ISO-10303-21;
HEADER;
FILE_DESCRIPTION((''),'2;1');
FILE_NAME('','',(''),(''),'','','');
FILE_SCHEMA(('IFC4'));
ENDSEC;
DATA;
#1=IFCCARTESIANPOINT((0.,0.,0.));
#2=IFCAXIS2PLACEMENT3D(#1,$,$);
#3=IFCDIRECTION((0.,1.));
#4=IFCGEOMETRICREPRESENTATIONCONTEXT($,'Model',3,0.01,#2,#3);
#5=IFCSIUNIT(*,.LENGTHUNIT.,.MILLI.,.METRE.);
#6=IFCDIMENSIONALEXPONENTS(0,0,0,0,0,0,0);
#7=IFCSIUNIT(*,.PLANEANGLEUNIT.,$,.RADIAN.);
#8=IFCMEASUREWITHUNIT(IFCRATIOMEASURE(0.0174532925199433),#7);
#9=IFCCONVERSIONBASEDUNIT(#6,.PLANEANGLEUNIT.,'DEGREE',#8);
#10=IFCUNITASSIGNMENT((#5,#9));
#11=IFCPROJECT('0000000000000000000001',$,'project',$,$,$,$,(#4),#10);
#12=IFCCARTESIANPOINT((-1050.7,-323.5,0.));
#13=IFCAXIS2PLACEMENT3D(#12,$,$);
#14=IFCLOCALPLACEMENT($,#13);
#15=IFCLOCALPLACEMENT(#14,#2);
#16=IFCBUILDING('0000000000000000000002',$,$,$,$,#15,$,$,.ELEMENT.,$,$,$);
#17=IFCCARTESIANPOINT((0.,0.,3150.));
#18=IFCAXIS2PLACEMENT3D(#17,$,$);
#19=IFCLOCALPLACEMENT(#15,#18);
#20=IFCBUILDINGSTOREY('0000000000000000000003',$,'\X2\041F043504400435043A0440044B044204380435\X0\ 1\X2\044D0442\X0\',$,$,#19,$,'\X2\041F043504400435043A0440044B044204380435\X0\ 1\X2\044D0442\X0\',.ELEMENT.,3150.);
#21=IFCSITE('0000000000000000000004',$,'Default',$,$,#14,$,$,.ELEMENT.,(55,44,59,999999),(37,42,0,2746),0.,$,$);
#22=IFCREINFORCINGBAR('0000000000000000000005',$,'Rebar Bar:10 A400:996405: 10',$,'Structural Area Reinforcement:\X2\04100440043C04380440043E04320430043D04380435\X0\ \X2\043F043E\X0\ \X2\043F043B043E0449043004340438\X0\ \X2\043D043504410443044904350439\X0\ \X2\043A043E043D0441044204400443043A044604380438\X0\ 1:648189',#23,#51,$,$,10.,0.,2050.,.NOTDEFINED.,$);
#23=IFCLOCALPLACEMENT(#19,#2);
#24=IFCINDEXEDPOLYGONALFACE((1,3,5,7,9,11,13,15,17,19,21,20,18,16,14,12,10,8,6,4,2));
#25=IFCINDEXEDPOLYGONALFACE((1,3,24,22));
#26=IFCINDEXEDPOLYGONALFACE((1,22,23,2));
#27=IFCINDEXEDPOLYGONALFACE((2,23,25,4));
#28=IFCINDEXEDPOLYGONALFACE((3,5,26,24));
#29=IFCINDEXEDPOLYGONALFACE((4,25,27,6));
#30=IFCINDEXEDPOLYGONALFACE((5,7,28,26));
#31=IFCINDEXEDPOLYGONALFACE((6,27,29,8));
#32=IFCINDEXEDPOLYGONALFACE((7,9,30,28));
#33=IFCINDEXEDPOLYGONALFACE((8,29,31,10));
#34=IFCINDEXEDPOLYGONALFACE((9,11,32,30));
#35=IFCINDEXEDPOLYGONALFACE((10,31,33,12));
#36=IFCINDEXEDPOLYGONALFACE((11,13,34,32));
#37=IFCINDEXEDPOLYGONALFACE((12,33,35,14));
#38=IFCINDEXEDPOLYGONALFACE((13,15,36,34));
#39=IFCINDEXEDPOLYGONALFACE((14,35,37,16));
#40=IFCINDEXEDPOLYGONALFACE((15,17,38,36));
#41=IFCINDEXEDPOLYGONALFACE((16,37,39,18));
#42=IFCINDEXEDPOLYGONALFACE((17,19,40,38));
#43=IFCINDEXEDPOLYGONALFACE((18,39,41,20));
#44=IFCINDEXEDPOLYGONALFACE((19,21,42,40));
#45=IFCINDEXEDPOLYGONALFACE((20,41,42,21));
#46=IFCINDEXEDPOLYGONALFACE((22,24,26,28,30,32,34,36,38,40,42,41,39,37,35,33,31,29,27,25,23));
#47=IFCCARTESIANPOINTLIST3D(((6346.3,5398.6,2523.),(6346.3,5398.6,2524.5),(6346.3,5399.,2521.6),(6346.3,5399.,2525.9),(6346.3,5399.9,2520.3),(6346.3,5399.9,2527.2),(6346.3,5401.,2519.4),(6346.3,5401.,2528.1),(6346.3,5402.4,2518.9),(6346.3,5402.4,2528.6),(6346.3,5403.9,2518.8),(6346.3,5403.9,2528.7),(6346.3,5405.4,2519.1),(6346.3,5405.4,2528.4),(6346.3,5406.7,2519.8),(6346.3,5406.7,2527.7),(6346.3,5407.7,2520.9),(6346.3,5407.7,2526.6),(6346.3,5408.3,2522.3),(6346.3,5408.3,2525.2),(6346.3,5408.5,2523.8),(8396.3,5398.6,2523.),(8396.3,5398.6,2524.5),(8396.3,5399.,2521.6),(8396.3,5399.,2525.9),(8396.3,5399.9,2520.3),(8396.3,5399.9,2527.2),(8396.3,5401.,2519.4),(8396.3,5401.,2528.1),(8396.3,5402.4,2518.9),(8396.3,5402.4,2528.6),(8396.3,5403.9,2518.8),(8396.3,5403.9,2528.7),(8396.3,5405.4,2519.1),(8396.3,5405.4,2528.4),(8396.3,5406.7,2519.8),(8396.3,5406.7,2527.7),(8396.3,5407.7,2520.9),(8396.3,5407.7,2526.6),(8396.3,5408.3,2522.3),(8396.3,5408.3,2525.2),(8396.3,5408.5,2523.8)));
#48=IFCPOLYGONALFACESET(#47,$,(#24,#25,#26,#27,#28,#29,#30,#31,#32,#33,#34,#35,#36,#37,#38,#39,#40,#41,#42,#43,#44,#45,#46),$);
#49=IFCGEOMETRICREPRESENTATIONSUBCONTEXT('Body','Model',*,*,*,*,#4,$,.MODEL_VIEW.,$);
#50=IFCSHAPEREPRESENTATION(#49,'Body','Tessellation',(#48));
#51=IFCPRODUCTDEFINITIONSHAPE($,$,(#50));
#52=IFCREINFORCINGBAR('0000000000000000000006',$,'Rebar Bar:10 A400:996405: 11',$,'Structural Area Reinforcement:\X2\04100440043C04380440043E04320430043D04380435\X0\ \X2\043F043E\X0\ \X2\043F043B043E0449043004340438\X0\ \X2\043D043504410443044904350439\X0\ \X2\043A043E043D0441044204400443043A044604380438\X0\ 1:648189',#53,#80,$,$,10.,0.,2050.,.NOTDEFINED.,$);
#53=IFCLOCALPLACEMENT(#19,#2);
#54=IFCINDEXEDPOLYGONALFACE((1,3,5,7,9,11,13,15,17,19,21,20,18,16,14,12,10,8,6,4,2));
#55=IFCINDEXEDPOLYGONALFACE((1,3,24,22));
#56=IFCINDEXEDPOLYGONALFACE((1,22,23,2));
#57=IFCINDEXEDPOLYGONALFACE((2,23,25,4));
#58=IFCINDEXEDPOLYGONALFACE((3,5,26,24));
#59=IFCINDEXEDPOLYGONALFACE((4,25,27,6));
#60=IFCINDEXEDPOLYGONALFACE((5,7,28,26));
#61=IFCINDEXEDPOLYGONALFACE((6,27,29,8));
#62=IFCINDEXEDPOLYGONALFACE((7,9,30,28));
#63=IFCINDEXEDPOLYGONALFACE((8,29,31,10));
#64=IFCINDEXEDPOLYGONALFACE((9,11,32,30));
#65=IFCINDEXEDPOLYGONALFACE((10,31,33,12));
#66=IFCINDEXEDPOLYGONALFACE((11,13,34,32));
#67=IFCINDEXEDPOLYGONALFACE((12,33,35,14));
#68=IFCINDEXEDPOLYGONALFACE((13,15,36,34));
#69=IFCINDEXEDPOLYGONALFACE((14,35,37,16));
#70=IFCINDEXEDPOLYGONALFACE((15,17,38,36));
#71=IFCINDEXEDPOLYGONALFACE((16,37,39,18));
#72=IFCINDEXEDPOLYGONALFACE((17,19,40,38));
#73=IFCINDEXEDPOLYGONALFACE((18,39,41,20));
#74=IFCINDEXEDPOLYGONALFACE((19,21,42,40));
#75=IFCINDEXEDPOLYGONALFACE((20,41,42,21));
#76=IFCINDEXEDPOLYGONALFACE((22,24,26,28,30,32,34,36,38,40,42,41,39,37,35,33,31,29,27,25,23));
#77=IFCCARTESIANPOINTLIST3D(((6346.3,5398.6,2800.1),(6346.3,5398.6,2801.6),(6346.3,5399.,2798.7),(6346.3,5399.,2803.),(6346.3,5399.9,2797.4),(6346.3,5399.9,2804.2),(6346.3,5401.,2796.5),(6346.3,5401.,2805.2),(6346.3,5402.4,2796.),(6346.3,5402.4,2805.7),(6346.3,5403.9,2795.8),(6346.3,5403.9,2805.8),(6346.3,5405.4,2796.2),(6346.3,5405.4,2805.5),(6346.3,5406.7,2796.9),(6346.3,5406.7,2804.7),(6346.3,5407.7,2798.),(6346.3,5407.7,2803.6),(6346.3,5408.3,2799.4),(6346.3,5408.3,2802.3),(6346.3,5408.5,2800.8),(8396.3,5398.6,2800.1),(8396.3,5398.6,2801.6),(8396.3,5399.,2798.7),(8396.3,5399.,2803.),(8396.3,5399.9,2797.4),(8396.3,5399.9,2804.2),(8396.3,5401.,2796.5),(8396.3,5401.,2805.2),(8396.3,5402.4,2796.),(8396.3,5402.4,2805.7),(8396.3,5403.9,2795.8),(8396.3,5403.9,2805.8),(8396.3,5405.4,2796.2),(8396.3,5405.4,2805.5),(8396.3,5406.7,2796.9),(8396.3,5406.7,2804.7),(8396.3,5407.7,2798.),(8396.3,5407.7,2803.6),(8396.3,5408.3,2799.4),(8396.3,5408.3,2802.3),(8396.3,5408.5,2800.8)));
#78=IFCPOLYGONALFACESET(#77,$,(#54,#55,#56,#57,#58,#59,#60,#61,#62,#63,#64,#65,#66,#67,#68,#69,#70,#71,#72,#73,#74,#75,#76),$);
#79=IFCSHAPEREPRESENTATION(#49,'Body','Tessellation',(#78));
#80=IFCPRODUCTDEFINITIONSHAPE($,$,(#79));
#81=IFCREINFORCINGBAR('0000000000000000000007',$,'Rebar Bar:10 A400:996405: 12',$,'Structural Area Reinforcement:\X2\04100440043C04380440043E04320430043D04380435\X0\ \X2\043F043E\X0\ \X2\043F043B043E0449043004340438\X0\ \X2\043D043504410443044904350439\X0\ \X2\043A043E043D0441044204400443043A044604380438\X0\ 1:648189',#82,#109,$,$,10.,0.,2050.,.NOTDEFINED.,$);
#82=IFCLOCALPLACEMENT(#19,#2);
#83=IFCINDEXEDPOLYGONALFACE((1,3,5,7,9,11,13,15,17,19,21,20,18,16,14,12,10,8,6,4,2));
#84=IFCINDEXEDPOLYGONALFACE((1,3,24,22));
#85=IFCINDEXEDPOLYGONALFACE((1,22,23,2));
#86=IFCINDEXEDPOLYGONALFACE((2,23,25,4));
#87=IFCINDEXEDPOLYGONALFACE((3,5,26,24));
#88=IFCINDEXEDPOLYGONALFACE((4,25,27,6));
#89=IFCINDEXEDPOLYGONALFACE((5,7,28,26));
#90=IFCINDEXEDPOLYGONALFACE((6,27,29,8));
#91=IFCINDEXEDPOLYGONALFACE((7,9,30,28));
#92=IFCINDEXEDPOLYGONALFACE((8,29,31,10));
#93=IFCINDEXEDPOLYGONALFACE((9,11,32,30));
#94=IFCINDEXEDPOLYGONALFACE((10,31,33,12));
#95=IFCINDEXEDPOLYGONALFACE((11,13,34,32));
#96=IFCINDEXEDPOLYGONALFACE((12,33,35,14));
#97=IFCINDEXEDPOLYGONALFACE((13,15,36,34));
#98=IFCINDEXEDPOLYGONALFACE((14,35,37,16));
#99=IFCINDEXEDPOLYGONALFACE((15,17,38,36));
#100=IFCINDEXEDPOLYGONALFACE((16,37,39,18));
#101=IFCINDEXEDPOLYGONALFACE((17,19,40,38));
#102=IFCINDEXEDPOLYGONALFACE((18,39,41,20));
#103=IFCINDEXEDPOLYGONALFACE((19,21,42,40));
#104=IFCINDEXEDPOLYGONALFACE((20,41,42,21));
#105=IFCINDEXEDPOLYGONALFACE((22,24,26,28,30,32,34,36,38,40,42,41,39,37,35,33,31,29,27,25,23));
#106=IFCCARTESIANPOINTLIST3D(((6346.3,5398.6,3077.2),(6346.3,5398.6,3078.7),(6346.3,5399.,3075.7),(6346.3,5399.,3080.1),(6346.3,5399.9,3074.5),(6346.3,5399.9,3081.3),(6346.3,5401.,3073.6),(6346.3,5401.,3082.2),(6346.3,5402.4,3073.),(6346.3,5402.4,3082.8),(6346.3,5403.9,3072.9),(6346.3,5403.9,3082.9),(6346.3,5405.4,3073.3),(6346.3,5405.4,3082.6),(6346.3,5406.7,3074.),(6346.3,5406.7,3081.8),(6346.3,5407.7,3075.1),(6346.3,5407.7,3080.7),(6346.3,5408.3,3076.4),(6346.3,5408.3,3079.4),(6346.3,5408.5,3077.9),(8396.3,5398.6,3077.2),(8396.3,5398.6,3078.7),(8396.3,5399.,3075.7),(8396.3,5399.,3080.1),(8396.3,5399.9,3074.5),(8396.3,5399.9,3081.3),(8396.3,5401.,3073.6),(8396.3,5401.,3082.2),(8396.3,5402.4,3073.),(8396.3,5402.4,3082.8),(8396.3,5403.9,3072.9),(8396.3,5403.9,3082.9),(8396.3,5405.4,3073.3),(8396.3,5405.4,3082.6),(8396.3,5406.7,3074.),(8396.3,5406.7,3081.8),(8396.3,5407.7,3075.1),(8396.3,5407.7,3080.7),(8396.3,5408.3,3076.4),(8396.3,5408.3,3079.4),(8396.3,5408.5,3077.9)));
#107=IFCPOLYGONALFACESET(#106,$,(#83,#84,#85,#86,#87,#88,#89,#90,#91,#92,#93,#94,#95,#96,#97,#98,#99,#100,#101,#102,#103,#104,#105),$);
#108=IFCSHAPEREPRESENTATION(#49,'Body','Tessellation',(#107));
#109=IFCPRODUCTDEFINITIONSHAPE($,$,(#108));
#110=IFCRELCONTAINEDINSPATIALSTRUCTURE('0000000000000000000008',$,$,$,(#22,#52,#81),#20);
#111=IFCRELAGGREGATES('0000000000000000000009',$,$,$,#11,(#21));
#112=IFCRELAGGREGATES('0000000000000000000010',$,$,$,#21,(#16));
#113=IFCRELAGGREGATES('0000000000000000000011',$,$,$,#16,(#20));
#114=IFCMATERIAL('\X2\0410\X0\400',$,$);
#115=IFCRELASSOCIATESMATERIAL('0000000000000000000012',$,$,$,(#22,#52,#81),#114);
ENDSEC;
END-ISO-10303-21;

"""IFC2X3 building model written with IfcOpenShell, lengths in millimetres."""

from ifc_helpers import new_model, entity, si_unit, converted_unit, direction, frame, origin, place, context, subcontext, project, spatial, material, element, save


model = new_model("IFC2X3")

# Units and contexts
model_context = context("Model", 3, precision=0.01, world=origin(), true_north=direction((0.0, 1.0)))
body_context = subcontext(model_context, "Body", "Model", "MODEL_VIEW")
ifc_project = project(units=[si_unit("LENGTHUNIT", "METRE", prefix="MILLI"), converted_unit("PLANEANGLEUNIT", "DEGREE", entity("IfcRatioMeasure", 0.0174532925199433), si_unit("PLANEANGLEUNIT", "RADIAN"), dimensions=[0, 0, 0, 0, 0, 0, 0])], contexts=[model_context])

# Site, building, storey
site_placement = place(None, frame((-1050.7, -323.5, 0.0)))
site = spatial("IfcSite", under=ifc_project, at=site_placement, Name="Default", CompositionType="ELEMENT", RefLatitude=(55, 44, 59, 999999), RefLongitude=(37, 42, 0, 2746), RefElevation=0.0)
building_placement = place(site_placement, origin())
building = spatial("IfcBuilding", under=site, at=building_placement, CompositionType="ELEMENT")
storey_placement = place(building_placement, frame((0.0, 0.0, 3150.0)))
storey = spatial("IfcBuildingStorey", under=building, at=storey_placement, Name="Перекрытие 1эт", LongName="Перекрытие 1эт", CompositionType="ELEMENT", Elevation=3150.0)

# Reinforcing bars
ifc_material = material(Name="А400")
reinforcing_bar_1_placement = place(storey_placement, origin())
element("IfcReinforcingBar", 1, at=reinforcing_bar_1_placement, inside=storey, material=ifc_material, Name="Rebar Bar:10 A400:996405: 10", ObjectType="Structural Area Reinforcement:Армирование по площади несущей конструкции 1:648189", BarLength=2050.0, BarRole="NOTDEFINED", CrossSectionArea=0.0, NominalDiameter=10.0, context=body_context, shape_type="AdvancedSweptSolid", body=[
    entity("IfcSweptDiskSolid", entity("IfcCompositeCurve", [entity("IfcCompositeCurveSegment", "CONTINUOUS", True, entity("IfcPolyline", [entity("IfcCartesianPoint", [6346.3, 5403.5, 2523.8]), entity("IfcCartesianPoint", [8396.3, 5403.5, 2523.8])]))], False), 5.0, None, 0.0, 1.0),
])
reinforcing_bar_2_placement = place(storey_placement, origin())
element("IfcReinforcingBar", 2, at=reinforcing_bar_2_placement, inside=storey, material=ifc_material, Name="Rebar Bar:10 A400:996405: 11", ObjectType="Structural Area Reinforcement:Армирование по площади несущей конструкции 1:648189", BarLength=2050.0, BarRole="NOTDEFINED", CrossSectionArea=0.0, NominalDiameter=10.0, context=body_context, shape_type="AdvancedSweptSolid", body=[
    entity("IfcSweptDiskSolid", entity("IfcCompositeCurve", [entity("IfcCompositeCurveSegment", "CONTINUOUS", True, entity("IfcPolyline", [entity("IfcCartesianPoint", [6346.3, 5403.5, 2800.8]), entity("IfcCartesianPoint", [8396.3, 5403.5, 2800.8])]))], False), 5.0, None, 0.0, 1.0),
])
reinforcing_bar_3_placement = place(storey_placement, origin())
element("IfcReinforcingBar", 3, at=reinforcing_bar_3_placement, inside=storey, material=ifc_material, Name="Rebar Bar:10 A400:996405: 12", ObjectType="Structural Area Reinforcement:Армирование по площади несущей конструкции 1:648189", BarLength=2050.0, BarRole="NOTDEFINED", CrossSectionArea=0.0, NominalDiameter=10.0, context=body_context, shape_type="AdvancedSweptSolid", body=[
    entity("IfcSweptDiskSolid", entity("IfcCompositeCurve", [entity("IfcCompositeCurveSegment", "CONTINUOUS", True, entity("IfcPolyline", [entity("IfcCartesianPoint", [6346.3, 5403.5, 3077.9]), entity("IfcCartesianPoint", [8396.3, 5403.5, 3077.9])]))], False), 5.0, None, 0.0, 1.0),
])

save(model, "model.ifc")
